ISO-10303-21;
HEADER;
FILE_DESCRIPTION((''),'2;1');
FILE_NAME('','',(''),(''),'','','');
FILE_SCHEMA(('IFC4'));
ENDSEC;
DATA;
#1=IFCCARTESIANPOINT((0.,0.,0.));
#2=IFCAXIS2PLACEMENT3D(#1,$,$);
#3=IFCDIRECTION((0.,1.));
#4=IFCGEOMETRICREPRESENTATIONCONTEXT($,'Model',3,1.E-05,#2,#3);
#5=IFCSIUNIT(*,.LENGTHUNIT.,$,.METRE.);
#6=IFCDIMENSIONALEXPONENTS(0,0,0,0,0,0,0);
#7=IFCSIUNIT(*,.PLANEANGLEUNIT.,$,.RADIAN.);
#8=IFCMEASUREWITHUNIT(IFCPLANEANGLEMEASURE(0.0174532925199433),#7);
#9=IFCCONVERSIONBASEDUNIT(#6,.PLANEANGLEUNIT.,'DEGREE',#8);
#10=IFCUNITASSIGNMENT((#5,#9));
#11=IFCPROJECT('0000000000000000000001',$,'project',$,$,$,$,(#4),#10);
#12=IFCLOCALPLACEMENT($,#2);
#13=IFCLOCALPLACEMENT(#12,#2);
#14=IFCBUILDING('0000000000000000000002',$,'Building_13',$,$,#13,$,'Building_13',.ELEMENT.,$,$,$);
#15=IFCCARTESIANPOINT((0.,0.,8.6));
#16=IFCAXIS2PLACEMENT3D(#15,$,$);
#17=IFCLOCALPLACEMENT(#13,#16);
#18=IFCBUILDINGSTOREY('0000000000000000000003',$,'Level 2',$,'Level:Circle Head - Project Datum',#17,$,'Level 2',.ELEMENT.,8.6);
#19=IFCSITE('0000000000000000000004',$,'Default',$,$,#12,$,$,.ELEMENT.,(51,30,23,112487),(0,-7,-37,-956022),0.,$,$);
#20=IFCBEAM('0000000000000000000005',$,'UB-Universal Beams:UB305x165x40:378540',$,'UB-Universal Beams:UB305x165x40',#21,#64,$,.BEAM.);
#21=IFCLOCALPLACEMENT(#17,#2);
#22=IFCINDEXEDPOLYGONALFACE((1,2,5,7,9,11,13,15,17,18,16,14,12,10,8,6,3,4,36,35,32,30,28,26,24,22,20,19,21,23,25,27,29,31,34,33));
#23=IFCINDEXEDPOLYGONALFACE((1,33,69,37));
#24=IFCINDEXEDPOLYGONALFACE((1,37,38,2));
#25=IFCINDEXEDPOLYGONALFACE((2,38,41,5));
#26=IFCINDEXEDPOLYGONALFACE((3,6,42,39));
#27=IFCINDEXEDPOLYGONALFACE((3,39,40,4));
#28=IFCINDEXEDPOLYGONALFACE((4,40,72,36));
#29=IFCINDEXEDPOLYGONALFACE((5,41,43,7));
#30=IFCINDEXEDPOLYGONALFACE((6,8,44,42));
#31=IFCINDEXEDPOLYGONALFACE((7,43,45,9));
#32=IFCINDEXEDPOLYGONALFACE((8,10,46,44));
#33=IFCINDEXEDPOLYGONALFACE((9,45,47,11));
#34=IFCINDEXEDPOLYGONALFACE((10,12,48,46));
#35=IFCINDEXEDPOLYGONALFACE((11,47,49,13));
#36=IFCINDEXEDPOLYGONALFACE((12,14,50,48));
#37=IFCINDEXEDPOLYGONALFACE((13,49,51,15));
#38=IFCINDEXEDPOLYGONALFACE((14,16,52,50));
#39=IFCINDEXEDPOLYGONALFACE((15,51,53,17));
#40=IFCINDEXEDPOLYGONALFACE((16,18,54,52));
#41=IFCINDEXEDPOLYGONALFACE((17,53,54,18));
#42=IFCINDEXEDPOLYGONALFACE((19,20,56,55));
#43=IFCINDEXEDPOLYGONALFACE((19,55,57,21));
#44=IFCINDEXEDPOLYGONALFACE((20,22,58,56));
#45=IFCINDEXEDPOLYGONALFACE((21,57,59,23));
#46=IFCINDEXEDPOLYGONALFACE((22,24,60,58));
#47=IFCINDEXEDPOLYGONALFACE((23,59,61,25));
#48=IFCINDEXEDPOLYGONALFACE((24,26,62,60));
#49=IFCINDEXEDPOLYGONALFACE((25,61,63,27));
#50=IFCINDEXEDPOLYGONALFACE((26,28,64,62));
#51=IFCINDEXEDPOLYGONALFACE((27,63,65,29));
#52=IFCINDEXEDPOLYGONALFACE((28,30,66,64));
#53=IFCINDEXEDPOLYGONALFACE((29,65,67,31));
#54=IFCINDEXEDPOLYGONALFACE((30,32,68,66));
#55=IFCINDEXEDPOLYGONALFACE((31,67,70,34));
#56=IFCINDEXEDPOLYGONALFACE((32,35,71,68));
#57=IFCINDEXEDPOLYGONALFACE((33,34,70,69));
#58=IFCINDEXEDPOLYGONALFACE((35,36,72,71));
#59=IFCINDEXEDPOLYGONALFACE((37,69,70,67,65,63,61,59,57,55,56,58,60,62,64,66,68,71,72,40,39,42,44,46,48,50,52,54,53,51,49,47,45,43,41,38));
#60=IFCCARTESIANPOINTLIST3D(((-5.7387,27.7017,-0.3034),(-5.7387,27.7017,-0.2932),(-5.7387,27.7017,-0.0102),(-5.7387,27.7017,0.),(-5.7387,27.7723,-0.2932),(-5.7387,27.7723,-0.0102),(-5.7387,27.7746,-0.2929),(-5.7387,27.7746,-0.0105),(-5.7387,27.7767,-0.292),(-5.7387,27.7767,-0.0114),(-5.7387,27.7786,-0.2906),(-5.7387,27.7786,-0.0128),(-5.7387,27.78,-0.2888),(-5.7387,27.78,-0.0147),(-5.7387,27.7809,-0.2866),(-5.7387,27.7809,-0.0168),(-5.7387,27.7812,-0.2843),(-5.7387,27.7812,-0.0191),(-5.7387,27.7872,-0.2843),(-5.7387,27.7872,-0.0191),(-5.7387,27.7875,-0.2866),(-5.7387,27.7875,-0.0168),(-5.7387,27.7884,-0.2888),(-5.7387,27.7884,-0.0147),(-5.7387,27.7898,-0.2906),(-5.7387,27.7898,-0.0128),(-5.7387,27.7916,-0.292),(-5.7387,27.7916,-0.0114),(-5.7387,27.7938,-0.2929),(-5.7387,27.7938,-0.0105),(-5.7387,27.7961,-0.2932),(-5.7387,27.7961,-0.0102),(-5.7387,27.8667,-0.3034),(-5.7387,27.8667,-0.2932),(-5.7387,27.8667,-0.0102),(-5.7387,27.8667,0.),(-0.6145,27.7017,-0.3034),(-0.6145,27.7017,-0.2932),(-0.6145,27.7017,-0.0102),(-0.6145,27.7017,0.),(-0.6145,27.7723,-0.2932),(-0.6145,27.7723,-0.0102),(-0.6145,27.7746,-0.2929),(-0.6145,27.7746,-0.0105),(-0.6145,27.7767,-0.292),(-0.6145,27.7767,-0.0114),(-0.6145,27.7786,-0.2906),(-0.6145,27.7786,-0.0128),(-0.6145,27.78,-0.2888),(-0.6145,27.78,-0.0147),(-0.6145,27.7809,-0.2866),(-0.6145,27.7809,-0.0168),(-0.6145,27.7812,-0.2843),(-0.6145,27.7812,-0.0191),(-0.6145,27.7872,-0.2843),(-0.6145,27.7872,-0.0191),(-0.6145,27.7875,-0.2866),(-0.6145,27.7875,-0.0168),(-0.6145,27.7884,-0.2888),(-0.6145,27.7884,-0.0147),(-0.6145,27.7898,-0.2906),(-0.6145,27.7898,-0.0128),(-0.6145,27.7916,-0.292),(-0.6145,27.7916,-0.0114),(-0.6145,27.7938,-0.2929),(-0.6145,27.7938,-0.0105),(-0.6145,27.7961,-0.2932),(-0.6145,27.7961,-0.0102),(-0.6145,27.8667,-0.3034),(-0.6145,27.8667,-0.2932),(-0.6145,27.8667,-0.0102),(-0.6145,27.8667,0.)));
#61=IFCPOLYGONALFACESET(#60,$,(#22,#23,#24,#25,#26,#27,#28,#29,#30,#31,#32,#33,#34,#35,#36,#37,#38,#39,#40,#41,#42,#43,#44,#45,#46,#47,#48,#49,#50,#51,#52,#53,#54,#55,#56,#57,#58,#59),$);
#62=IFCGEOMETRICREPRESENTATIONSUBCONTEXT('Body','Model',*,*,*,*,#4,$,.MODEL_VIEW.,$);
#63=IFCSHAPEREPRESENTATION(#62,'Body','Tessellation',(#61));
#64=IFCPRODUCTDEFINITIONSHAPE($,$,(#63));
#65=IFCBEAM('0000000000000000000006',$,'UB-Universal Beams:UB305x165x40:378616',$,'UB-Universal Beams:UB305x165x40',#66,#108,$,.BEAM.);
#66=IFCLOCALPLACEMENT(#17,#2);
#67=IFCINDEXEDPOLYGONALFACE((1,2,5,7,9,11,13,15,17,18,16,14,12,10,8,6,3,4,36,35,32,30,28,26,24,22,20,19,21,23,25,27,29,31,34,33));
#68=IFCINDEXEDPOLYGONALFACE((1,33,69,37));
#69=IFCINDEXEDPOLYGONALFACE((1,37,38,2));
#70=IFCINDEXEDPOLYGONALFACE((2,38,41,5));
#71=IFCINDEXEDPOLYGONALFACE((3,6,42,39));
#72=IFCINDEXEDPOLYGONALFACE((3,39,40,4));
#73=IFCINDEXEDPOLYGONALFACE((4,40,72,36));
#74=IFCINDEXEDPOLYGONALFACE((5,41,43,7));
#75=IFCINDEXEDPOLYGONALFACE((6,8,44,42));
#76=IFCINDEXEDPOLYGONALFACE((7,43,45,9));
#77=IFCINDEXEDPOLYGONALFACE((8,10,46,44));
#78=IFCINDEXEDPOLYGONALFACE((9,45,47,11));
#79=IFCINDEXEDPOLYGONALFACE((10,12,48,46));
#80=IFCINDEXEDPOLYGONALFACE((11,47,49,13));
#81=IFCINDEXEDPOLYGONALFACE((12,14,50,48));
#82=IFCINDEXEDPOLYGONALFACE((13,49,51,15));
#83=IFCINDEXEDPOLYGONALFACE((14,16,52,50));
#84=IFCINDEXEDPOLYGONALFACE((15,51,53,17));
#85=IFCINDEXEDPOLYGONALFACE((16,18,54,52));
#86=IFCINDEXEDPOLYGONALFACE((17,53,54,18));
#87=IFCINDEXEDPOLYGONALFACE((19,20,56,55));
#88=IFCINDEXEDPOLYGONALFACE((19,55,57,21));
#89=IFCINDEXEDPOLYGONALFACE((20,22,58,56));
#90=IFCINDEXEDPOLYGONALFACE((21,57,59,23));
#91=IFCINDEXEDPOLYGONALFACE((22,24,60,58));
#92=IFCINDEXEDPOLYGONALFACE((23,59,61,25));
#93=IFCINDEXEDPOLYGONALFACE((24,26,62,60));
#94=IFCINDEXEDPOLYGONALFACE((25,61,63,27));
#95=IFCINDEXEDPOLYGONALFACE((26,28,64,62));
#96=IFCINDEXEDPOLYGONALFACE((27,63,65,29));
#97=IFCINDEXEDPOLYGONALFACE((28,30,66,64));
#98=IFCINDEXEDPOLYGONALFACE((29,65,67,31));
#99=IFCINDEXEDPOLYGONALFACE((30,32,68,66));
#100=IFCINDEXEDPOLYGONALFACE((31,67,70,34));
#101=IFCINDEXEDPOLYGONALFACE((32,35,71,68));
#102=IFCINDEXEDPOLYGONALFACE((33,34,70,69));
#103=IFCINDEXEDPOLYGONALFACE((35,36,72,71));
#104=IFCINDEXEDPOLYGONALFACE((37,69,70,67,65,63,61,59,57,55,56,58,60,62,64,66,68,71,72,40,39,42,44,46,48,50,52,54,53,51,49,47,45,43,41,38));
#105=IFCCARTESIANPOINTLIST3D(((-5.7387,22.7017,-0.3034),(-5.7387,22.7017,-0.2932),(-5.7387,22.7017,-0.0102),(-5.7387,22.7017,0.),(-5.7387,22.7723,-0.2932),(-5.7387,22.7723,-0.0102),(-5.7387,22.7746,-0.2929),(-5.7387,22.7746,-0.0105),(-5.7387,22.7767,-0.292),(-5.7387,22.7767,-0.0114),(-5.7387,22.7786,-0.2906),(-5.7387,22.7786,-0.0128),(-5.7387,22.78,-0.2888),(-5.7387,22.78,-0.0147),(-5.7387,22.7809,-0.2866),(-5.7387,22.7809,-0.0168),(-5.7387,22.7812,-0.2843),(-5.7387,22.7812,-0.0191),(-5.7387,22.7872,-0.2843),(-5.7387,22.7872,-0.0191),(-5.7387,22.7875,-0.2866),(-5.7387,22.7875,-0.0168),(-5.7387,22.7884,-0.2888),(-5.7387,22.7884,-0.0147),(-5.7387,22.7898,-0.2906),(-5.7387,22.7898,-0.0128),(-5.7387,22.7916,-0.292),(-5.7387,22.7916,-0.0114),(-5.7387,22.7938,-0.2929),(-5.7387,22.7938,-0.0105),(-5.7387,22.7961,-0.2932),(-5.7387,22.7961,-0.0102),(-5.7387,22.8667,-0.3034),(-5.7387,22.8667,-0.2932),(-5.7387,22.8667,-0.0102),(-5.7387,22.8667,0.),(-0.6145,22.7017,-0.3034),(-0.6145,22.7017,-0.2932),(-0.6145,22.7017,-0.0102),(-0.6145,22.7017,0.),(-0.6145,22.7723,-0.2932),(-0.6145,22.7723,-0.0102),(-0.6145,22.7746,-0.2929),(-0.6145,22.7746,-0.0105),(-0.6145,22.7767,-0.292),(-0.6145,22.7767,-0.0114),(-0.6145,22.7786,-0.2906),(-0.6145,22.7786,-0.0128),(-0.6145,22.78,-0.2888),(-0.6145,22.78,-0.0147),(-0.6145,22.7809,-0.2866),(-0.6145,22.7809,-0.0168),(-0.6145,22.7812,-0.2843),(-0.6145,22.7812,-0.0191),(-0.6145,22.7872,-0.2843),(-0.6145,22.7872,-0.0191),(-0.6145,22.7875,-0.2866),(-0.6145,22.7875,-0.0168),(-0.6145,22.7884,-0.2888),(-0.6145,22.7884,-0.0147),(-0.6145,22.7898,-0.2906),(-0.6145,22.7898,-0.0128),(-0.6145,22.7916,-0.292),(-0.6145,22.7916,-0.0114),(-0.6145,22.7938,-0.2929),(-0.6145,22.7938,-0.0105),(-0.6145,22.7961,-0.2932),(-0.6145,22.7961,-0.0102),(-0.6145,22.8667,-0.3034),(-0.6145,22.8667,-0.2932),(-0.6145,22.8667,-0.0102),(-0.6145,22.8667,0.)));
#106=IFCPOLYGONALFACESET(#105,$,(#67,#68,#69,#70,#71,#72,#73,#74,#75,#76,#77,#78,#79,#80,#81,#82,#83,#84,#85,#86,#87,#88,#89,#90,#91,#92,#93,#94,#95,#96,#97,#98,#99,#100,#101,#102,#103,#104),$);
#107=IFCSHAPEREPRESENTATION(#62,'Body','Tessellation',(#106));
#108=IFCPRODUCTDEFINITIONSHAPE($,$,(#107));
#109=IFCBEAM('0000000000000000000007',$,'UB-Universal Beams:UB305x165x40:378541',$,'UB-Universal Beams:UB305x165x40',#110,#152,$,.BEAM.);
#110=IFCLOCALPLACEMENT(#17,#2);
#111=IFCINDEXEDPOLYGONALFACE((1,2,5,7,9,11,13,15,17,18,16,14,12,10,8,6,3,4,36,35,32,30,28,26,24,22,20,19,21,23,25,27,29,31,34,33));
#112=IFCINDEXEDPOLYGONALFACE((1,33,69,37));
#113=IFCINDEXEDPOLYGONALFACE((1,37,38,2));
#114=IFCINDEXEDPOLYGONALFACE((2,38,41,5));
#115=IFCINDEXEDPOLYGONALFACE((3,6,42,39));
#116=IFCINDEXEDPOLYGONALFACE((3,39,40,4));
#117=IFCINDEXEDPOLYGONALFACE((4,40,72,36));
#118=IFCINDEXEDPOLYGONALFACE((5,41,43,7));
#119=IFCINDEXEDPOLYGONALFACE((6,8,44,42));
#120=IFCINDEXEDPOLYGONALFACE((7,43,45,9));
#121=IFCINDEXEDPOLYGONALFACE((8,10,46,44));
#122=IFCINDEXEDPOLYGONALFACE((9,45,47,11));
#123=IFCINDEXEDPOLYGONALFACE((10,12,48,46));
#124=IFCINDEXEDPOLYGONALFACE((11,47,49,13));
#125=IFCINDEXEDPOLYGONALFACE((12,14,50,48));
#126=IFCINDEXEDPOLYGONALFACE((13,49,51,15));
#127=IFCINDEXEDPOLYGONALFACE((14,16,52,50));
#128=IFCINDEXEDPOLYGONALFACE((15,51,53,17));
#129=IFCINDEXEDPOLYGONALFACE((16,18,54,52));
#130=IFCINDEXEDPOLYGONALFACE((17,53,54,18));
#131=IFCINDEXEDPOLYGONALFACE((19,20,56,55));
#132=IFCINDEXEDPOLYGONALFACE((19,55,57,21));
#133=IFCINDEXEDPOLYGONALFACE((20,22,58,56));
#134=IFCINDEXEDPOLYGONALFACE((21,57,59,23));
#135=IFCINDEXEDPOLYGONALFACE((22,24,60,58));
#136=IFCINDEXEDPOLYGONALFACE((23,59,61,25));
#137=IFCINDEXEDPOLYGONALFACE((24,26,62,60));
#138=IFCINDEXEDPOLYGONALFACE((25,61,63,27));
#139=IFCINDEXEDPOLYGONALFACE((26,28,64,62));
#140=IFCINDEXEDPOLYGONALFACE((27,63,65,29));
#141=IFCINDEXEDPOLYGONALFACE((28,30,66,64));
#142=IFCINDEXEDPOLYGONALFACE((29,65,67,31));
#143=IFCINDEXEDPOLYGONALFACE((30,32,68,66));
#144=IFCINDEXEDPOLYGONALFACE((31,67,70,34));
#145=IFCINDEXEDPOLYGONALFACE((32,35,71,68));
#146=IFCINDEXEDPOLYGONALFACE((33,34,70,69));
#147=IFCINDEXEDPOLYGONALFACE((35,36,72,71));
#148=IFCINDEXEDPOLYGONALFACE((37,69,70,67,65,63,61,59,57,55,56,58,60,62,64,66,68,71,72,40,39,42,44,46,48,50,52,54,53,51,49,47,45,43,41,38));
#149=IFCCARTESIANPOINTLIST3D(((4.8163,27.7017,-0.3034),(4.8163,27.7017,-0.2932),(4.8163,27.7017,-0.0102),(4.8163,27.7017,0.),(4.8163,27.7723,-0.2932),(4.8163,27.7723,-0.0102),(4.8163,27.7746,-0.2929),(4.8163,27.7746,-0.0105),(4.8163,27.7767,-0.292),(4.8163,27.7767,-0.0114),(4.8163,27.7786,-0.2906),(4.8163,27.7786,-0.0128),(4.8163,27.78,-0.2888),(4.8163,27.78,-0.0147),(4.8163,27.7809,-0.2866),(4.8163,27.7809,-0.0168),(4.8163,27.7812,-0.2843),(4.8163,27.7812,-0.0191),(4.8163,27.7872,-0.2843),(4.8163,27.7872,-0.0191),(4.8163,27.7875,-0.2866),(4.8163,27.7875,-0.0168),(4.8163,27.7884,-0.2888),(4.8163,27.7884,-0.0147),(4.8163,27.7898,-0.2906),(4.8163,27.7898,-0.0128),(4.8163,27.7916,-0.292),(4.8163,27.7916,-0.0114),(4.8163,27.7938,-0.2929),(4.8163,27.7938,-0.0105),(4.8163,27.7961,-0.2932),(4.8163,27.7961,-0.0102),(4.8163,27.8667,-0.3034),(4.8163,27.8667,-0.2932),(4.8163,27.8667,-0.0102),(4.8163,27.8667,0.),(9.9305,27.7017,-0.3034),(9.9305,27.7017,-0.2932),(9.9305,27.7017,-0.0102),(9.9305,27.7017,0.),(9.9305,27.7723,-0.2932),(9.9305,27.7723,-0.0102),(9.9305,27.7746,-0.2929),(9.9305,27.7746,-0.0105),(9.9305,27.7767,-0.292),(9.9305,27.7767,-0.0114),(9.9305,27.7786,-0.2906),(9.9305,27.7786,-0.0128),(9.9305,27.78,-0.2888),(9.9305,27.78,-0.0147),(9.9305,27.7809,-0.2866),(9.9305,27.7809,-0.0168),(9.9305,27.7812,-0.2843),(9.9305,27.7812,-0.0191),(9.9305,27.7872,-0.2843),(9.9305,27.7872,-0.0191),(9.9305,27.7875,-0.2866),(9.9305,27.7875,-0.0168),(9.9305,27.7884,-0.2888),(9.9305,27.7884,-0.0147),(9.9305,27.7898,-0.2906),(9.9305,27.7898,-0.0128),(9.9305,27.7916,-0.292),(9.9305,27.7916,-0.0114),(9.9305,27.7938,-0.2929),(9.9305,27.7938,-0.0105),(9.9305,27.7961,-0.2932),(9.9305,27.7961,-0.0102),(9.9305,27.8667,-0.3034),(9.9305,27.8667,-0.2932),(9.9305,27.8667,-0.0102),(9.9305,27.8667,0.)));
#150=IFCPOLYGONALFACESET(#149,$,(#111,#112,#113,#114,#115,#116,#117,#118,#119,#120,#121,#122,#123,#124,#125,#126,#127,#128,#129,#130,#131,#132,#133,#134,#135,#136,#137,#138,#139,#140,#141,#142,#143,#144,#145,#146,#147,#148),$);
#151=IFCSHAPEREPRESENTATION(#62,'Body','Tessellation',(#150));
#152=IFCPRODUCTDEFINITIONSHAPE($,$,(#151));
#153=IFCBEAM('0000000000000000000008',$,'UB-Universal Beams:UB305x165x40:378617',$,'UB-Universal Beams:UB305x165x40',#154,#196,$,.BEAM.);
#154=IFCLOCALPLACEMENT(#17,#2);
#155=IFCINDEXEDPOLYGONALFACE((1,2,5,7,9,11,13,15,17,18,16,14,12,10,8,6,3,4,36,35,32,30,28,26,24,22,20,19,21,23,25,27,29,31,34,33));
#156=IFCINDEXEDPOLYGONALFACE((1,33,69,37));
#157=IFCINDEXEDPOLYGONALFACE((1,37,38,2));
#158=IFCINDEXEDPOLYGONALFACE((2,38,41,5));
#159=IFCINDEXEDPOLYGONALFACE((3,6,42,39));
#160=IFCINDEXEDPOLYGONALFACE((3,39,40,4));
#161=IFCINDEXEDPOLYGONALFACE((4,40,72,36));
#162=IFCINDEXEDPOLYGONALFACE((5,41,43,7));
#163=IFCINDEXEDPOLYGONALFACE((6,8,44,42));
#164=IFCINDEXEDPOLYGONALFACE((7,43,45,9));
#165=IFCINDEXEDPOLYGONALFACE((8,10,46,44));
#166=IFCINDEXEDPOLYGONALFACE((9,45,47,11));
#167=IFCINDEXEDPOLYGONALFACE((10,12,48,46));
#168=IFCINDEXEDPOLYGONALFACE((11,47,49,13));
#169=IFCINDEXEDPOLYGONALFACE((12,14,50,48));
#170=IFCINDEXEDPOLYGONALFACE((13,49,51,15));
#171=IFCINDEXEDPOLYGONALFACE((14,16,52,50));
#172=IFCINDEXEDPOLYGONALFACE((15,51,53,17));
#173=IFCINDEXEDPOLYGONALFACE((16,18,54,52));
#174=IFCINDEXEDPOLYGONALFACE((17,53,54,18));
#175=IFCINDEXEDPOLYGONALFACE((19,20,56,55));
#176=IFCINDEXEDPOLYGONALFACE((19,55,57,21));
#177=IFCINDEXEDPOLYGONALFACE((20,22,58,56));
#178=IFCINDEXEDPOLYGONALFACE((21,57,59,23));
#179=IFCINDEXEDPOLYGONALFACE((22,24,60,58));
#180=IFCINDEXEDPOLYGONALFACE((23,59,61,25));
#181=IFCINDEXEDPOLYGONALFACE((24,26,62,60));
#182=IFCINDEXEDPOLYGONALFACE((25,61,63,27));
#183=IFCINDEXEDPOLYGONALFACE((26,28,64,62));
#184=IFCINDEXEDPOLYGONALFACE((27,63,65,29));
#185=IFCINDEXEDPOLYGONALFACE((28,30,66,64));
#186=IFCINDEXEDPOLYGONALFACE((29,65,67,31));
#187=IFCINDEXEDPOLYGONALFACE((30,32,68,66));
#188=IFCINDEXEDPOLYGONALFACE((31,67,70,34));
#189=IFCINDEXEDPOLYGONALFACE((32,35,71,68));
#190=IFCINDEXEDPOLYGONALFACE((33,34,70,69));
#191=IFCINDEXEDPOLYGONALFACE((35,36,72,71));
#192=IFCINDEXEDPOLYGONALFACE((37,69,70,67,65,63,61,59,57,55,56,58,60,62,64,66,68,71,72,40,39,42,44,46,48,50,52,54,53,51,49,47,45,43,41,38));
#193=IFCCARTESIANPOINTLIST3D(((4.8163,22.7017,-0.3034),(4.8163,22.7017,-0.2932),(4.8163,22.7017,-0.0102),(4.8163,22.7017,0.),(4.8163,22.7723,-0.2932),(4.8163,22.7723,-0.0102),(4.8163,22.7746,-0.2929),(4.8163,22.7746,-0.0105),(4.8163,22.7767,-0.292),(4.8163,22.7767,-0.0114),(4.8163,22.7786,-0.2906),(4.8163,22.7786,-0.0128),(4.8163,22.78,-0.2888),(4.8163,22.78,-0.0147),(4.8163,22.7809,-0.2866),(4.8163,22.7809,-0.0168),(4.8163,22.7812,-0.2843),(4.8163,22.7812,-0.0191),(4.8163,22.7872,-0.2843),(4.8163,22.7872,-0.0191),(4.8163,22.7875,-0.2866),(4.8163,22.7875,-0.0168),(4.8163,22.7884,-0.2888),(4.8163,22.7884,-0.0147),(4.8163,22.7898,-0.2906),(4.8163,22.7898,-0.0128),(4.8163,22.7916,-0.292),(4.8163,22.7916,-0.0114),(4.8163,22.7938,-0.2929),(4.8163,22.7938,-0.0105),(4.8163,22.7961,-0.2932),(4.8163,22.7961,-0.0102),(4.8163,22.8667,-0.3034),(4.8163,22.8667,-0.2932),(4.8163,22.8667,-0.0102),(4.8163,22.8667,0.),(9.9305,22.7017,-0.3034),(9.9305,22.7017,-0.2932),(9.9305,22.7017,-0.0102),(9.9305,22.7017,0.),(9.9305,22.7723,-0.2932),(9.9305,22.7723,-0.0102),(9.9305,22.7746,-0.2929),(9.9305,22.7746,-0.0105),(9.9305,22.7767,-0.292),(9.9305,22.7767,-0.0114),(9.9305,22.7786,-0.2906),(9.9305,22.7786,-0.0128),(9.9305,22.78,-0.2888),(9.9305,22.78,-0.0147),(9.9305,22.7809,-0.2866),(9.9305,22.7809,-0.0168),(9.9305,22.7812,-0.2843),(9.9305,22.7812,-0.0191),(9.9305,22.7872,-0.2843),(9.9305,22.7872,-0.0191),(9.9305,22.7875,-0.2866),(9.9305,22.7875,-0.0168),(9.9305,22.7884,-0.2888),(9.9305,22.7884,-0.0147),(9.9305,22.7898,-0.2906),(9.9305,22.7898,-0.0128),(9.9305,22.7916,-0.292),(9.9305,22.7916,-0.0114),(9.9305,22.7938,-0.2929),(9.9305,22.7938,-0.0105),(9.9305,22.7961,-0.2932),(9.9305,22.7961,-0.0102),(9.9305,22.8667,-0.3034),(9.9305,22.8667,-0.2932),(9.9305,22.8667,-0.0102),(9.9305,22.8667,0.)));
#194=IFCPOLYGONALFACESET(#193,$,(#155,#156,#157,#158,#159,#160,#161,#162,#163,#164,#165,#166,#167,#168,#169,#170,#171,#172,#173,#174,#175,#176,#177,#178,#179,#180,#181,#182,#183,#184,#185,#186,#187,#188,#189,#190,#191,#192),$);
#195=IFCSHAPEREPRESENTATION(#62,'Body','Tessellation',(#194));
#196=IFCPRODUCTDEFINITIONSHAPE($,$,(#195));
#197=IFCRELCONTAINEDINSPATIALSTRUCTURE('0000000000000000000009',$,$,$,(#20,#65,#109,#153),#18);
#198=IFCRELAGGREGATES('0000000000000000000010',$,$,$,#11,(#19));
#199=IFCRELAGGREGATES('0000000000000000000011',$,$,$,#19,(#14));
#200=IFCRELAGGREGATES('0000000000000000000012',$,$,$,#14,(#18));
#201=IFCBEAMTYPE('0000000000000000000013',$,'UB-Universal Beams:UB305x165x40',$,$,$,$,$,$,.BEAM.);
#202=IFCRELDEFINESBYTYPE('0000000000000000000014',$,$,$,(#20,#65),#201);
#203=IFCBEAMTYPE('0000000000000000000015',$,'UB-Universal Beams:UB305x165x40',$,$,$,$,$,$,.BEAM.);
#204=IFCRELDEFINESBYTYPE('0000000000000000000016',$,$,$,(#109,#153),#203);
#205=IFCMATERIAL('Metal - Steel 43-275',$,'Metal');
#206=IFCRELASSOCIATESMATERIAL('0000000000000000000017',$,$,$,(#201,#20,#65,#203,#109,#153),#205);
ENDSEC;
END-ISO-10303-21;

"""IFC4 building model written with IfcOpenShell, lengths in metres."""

from ifc_helpers import new_model, entity, si_unit, converted_unit, direction, frame, origin, place, context, subcontext, project, spatial, line, arc, indexed_curve, outline, extrude, source, transform, mapped, material, type_object, type_shapes, element, save


model = new_model("IFC4")

# Units and contexts
model_context = context("Model", 3, precision=1e-05, world=origin(), true_north=direction((0.0, 1.0)))
body_context = subcontext(model_context, "Body", "Model", "MODEL_VIEW")
ifc_project = project(units=[si_unit("LENGTHUNIT", "METRE"), converted_unit("PLANEANGLEUNIT", "DEGREE", entity("IfcPlaneAngleMeasure", 0.0174532925199433), si_unit("PLANEANGLEUNIT", "RADIAN"), dimensions=[0, 0, 0, 0, 0, 0, 0])], contexts=[model_context])

# Site, building, storey
site_placement = place(None, origin())
site = spatial("IfcSite", under=ifc_project, at=site_placement, Name="Default", CompositionType="ELEMENT", RefLatitude=(51, 30, 23, 112487), RefLongitude=(0, -7, -37, -956022), RefElevation=0.0)
building_placement = place(site_placement, origin())
building = spatial("IfcBuilding", under=site, at=building_placement, Name="Building_13", LongName="Building_13", CompositionType="ELEMENT")
storey_placement = place(building_placement, frame((0.0, 0.0, 8.6)))
storey = spatial("IfcBuildingStorey", under=building, at=storey_placement, Name="Level 2", ObjectType="Level:Circle Head - Project Datum", LongName="Level 2", CompositionType="ELEMENT", Elevation=8.6)

# Beams
ifc_material_1 = material(Name="Metal - Steel 43-275", Category="Metal")
beam_type_1 = type_object("IfcBeamType", Name="UB-Universal Beams:UB305x165x40", PredefinedType="BEAM", material=ifc_material_1)
shared_shape_1 = source(origin(), body_context, "Body", "SweptSolid", [
    extrude(outline(indexed_curve([(-0.0825, -0.1415), (-0.0825, -0.1517), (0.0825, -0.1517), (0.0825, -0.1415), (0.0119, -0.1415), (0.0056, -0.1389), (0.003, -0.1326), (0.003, 0.1326), (0.0056, 0.1389), (0.0119, 0.1415), (0.0825, 0.1415), (0.0825, 0.1517), (-0.0825, 0.1517), (-0.0825, 0.1415), (-0.0119, 0.1415), (-0.0056, 0.1389), (-0.003, 0.1326), (-0.003, -0.1326), (-0.0056, -0.1389), (-0.0119, -0.1415)], segments=[line(1, 2, 3, 4, 5), arc(5, 6, 7), line(7, 8), arc(8, 9, 10), line(10, 11, 12, 13, 14, 15), arc(15, 16, 17), line(17, 18), arc(18, 19, 20), line(20, 1)], self_intersect=False)), frame((-2.5621, 0.0, 0.0), z_axis=(-1.0, 0.0, 0.0), x_axis=(0.0, -1.0, 0.0)), (0.0, 0.0, -1.0), 5.1242),
])
type_shapes(beam_type_1, [shared_shape_1])
for number, where, name in (
    (1, (-3.1766, 27.7842, -0.1517), "UB-Universal Beams:UB305x165x40:378540"),
    (2, (-3.1766, 22.7842, -0.1517), "UB-Universal Beams:UB305x165x40:378616"),
):
    element("IfcBeam", number, at=place(storey_placement, frame(where)), inside=storey, type_object=beam_type_1, material=ifc_material_1, Name=name, ObjectType="UB-Universal Beams:UB305x165x40", PredefinedType="BEAM", context=body_context, shape_type="MappedRepresentation", body=[
        mapped(shared_shape_1, transform((0.0, 0.0, 0.0), scale=1.0)),
    ])
beam_type_2 = type_object("IfcBeamType", Name="UB-Universal Beams:UB305x165x40", PredefinedType="BEAM", material=ifc_material_1)
shared_shape_2 = source(origin(), body_context, "Body", "SweptSolid", [
    extrude(outline(indexed_curve([(-0.0825, -0.1415), (-0.0825, -0.1517), (0.0825, -0.1517), (0.0825, -0.1415), (0.0119, -0.1415), (0.0056, -0.1389), (0.003, -0.1326), (0.003, 0.1326), (0.0056, 0.1389), (0.0119, 0.1415), (0.0825, 0.1415), (0.0825, 0.1517), (-0.0825, 0.1517), (-0.0825, 0.1415), (-0.0119, 0.1415), (-0.0056, 0.1389), (-0.003, 0.1326), (-0.003, -0.1326), (-0.0056, -0.1389), (-0.0119, -0.1415)], segments=[line(1, 2, 3, 4, 5), arc(5, 6, 7), line(7, 8), arc(8, 9, 10), line(10, 11, 12, 13, 14, 15), arc(15, 16, 17), line(17, 18), arc(18, 19, 20), line(20, 1)], self_intersect=False)), frame((-2.5571, 0.0, 0.0), z_axis=(-1.0, 0.0, 0.0), x_axis=(0.0, -1.0, 0.0)), (0.0, 0.0, -1.0), 5.1142),
])
type_shapes(beam_type_2, [shared_shape_2])
for number, where, name in (
    (3, (7.3734, 27.7842, -0.1517), "UB-Universal Beams:UB305x165x40:378541"),
    (4, (7.3734, 22.7842, -0.1517), "UB-Universal Beams:UB305x165x40:378617"),
):
    element("IfcBeam", number, at=place(storey_placement, frame(where)), inside=storey, type_object=beam_type_2, material=ifc_material_1, Name=name, ObjectType="UB-Universal Beams:UB305x165x40", PredefinedType="BEAM", context=body_context, shape_type="MappedRepresentation", body=[
        mapped(shared_shape_2, transform((0.0, 0.0, 0.0), scale=1.0)),
    ])

save(model, "model.ifc")
